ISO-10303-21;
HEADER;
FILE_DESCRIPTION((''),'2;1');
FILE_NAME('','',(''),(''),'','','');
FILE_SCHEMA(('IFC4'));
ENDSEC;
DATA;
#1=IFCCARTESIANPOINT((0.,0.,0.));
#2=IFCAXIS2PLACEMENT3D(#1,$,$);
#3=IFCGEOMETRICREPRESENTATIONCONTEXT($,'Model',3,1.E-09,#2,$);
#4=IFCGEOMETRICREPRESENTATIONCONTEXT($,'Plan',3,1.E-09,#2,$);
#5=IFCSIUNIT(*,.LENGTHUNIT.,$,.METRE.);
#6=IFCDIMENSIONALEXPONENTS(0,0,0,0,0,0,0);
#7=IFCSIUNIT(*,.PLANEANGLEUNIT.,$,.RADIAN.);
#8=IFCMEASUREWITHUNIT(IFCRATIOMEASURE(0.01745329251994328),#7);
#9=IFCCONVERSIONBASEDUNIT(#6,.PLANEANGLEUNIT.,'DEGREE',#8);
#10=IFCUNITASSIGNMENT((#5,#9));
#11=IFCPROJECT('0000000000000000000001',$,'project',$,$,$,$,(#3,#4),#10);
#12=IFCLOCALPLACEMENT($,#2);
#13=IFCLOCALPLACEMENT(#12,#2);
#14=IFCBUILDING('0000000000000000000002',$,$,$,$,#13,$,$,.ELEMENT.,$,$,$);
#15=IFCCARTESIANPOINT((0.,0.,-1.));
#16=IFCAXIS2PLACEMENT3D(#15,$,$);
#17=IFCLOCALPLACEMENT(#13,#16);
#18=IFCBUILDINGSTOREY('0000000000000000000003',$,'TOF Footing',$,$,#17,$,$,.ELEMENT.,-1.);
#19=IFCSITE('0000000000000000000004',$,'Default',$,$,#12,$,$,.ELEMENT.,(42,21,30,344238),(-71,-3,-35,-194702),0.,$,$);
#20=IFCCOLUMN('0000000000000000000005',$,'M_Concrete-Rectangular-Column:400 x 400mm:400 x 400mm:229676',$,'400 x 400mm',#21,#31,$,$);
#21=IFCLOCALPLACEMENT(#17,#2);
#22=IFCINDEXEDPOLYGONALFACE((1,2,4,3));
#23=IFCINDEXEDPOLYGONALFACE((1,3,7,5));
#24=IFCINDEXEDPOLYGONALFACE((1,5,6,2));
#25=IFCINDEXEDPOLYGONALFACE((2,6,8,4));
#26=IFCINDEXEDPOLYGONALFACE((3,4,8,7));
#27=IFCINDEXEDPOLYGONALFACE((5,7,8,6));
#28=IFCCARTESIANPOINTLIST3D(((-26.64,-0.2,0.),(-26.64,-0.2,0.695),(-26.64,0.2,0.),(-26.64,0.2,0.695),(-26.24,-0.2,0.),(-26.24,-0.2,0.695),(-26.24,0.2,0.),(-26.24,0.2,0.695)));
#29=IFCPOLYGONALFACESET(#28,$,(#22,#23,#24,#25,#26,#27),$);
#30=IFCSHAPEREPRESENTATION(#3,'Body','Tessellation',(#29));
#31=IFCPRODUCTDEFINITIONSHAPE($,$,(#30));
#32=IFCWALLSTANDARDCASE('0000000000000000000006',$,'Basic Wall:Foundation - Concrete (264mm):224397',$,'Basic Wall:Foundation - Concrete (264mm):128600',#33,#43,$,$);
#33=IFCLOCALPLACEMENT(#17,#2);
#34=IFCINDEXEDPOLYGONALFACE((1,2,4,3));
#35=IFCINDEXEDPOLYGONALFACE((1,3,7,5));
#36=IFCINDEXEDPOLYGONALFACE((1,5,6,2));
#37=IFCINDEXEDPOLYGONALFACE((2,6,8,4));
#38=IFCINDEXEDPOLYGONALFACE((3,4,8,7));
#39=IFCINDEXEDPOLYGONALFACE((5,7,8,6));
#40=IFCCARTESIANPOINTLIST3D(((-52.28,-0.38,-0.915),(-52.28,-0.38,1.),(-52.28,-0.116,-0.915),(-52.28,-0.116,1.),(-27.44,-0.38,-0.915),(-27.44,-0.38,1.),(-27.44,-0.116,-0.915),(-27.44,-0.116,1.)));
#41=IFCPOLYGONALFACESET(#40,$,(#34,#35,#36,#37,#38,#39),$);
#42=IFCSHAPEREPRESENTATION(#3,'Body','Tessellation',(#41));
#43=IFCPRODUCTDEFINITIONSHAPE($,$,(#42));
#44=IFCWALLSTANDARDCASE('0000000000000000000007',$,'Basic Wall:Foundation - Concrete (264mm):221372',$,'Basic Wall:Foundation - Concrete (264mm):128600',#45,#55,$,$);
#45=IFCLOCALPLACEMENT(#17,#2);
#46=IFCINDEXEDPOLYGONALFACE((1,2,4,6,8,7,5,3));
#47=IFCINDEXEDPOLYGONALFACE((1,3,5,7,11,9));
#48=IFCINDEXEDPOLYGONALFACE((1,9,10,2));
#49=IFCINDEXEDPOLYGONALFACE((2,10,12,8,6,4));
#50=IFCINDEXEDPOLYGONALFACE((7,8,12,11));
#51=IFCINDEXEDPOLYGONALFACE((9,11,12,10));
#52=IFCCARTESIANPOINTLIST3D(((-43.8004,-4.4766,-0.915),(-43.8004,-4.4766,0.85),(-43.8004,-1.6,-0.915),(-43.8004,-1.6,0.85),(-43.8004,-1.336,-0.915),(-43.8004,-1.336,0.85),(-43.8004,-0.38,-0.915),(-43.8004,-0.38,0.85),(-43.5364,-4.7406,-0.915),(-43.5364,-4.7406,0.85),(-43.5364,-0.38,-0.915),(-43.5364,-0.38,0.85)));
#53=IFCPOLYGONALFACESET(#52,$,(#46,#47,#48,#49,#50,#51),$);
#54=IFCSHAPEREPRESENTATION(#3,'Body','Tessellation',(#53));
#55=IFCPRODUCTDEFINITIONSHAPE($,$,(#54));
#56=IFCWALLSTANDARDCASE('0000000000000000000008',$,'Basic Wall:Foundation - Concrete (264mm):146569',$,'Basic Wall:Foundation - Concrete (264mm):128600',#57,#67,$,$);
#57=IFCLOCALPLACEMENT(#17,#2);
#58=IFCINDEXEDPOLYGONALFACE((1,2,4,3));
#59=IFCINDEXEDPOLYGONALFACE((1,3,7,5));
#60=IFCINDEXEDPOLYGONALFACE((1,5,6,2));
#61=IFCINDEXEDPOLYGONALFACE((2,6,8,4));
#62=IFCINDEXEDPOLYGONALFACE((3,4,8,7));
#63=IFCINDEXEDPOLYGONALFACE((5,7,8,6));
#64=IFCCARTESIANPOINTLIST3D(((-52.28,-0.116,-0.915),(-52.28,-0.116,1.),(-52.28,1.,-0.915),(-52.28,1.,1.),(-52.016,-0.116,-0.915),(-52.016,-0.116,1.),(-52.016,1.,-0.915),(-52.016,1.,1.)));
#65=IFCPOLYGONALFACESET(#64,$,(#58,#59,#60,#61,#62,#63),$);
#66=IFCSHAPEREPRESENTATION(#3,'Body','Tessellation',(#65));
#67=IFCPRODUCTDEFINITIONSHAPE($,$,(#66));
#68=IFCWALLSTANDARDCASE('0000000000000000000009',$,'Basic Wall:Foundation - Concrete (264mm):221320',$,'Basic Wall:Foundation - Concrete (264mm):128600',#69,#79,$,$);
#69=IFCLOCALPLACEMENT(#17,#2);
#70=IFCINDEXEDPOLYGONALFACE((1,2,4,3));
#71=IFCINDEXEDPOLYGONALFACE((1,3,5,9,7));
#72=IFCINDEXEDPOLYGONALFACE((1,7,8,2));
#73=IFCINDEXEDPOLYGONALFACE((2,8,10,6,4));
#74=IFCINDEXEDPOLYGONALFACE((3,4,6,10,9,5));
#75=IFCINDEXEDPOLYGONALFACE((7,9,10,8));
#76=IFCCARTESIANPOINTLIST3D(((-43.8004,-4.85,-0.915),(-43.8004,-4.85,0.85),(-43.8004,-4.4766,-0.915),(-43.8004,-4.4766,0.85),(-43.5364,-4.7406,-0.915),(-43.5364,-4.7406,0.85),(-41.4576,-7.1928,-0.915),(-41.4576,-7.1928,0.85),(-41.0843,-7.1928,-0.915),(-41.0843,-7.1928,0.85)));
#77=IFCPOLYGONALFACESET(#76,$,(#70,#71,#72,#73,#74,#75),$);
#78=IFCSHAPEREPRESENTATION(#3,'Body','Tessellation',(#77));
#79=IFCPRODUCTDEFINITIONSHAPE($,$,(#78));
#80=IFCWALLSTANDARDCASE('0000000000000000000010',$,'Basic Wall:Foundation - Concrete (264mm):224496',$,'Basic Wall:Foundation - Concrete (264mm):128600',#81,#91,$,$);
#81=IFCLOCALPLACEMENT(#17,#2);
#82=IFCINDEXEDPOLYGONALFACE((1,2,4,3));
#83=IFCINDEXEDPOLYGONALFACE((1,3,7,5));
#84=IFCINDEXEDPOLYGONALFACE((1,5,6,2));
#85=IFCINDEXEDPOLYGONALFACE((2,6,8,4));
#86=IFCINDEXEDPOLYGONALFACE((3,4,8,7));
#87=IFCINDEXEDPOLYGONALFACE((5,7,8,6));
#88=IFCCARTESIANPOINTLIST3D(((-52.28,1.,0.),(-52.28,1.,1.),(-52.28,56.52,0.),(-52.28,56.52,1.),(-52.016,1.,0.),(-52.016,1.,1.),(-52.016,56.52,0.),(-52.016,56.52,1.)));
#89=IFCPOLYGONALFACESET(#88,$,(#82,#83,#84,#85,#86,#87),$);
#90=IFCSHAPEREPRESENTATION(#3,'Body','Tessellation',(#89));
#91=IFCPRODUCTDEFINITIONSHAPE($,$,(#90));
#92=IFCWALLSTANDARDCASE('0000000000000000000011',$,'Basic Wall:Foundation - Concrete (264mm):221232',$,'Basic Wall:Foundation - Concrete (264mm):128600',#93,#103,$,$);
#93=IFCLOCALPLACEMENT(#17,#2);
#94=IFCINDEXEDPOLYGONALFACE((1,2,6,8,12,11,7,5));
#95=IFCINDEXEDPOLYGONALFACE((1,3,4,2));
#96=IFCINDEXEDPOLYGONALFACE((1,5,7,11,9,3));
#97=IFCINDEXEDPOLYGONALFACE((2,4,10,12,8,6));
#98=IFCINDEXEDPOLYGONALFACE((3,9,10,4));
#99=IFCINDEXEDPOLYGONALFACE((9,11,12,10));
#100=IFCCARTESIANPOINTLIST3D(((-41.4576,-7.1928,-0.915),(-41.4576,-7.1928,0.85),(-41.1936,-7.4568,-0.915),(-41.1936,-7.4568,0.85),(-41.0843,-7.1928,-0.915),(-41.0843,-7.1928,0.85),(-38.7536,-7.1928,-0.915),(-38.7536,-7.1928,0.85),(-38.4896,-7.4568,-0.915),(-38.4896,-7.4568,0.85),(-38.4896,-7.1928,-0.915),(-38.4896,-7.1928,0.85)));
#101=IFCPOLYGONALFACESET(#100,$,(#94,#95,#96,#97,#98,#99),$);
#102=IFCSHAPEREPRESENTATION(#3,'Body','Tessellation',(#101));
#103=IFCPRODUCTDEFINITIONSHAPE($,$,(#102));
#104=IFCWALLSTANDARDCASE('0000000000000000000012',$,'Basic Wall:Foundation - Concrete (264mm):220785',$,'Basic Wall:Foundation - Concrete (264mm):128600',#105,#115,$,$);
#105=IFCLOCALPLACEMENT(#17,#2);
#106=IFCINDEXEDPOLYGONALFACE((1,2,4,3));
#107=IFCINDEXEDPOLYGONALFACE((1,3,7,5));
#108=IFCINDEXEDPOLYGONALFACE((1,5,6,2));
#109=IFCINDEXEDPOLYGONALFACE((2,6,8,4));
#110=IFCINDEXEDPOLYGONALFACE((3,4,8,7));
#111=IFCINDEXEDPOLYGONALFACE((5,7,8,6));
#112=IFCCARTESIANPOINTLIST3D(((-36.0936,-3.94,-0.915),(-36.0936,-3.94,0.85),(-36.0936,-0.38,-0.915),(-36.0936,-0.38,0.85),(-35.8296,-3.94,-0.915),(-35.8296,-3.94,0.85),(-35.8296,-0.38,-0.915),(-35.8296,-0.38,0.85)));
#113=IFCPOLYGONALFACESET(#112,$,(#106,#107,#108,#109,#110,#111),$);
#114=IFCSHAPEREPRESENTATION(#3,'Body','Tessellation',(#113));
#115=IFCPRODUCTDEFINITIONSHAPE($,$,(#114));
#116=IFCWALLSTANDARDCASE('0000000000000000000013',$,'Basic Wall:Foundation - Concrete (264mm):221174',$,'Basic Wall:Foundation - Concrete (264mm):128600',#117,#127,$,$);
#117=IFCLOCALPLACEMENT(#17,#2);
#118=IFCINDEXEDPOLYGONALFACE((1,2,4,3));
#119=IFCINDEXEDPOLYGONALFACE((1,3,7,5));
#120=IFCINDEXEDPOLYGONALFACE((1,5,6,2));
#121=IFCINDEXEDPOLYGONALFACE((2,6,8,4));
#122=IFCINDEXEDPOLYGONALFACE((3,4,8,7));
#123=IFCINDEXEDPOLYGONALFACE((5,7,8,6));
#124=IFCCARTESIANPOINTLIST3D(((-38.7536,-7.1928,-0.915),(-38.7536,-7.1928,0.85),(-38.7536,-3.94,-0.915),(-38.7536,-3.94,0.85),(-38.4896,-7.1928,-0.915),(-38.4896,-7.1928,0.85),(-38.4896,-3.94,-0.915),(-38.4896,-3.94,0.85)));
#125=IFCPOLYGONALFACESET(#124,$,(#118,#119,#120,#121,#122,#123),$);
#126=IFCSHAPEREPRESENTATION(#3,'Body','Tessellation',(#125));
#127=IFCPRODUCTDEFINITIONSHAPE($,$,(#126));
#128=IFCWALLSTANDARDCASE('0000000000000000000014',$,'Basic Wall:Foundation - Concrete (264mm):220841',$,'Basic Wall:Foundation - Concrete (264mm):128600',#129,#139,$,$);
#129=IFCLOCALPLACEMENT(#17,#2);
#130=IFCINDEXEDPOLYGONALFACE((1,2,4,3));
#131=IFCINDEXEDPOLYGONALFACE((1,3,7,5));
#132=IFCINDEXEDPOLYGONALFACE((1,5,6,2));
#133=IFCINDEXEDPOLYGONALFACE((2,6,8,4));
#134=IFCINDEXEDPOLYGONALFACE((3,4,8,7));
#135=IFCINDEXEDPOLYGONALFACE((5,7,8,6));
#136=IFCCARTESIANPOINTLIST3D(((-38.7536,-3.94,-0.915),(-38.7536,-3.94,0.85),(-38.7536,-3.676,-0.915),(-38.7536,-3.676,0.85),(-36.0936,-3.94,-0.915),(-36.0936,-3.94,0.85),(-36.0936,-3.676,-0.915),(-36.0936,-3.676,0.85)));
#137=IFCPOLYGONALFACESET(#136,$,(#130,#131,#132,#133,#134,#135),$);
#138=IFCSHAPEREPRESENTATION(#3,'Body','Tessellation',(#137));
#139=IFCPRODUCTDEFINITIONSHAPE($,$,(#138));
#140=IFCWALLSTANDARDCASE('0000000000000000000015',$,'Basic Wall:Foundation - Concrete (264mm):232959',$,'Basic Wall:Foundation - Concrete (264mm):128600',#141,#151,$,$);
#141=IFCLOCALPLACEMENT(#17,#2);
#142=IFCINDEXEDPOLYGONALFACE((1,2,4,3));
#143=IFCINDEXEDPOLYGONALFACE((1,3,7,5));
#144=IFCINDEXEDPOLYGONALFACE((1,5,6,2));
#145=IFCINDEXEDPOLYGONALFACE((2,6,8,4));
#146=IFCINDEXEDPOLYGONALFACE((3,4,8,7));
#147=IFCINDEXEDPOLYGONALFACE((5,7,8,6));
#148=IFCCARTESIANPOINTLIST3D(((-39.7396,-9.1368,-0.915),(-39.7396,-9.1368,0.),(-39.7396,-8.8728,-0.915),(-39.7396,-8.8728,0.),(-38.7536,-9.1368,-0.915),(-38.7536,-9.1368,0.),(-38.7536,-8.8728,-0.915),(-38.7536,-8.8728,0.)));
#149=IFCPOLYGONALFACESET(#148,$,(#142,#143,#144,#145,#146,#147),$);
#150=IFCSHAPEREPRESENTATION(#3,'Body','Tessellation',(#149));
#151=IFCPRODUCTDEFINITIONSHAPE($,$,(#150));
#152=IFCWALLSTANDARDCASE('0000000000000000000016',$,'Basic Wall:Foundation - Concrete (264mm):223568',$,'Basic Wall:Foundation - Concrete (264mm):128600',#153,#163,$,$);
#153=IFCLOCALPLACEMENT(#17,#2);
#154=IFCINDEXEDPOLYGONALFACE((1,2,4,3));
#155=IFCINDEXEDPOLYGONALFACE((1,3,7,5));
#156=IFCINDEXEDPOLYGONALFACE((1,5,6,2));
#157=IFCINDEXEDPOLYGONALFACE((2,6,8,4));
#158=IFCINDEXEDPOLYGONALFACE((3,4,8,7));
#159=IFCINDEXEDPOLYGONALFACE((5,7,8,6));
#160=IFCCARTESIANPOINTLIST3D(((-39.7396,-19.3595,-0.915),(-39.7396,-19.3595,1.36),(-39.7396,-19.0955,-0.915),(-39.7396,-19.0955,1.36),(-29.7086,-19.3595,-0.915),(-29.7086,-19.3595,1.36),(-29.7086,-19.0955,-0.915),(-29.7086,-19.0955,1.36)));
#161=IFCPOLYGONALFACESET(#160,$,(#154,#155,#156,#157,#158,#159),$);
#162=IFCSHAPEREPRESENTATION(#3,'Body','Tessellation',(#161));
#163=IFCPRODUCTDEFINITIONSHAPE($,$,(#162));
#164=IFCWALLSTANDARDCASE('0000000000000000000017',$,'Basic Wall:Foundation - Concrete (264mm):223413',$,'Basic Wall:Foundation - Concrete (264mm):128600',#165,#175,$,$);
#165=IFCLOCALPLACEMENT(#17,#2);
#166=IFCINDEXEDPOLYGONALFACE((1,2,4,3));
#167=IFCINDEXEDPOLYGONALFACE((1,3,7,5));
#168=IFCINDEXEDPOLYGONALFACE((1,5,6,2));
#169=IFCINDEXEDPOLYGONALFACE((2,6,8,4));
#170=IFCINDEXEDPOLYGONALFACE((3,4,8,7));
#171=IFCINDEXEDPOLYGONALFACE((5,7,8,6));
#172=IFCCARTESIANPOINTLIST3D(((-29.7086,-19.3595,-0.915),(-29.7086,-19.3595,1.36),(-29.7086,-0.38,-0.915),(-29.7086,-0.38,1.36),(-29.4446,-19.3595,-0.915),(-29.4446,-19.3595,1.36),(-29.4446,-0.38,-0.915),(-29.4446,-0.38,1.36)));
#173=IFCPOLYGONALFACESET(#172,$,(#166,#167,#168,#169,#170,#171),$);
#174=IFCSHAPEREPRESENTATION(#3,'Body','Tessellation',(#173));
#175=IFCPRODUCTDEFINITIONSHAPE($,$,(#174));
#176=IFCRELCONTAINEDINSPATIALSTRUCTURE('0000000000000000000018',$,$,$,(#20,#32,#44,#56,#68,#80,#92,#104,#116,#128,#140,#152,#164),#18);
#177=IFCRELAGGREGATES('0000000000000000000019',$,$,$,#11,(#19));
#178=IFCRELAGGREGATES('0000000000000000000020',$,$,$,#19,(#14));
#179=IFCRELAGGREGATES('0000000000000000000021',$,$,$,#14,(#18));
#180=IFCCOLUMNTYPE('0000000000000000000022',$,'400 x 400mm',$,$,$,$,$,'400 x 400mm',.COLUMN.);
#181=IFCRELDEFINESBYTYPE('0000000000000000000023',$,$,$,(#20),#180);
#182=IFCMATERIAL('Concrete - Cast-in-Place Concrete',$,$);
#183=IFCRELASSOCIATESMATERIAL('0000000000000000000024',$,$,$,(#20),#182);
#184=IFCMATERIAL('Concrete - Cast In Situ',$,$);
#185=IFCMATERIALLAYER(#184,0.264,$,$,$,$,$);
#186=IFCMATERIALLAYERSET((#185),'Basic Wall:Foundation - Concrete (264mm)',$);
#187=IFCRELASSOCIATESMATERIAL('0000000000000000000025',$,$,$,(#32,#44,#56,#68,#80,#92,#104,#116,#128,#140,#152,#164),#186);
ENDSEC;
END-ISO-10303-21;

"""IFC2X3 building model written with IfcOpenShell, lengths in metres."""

from ifc_helpers import new_model, entity, si_unit, converted_unit, frame, frame_2d, origin, place, context, project, spatial, polyline, rectangle, outline, extrude, source, transform, mapped, material, layer, layer_set, layer_usage, type_object, type_shapes, element, save


model = new_model("IFC2X3")

# Units and contexts
model_context = context("Model", 3, precision=1e-09, world=origin())
plan_context = context("Plan", 3, precision=1e-09, world=origin())
ifc_project = project(units=[si_unit("LENGTHUNIT", "METRE"), converted_unit("PLANEANGLEUNIT", "DEGREE", entity("IfcRatioMeasure", 0.01745329251994328), si_unit("PLANEANGLEUNIT", "RADIAN"), dimensions=[0, 0, 0, 0, 0, 0, 0])], contexts=[model_context, plan_context])

# Site, building, storey
site_placement = place(None, origin())
site = spatial("IfcSite", under=ifc_project, at=site_placement, Name="Default", CompositionType="ELEMENT", RefLatitude=(42, 21, 30, 344238), RefLongitude=(-71, -3, -35, -194702), RefElevation=0.0)
building_placement = place(site_placement, origin())
building = spatial("IfcBuilding", under=site, at=building_placement, CompositionType="ELEMENT")
storey_placement = place(building_placement, frame((0.0, 0.0, -1.0)))
storey = spatial("IfcBuildingStorey", under=building, at=storey_placement, Name="TOF Footing", CompositionType="ELEMENT", Elevation=-1.0)

# Column
ifc_material_1 = material(Name="Concrete - Cast-in-Place Concrete")
column_type_1 = type_object("IfcColumnType", Name="400 x 400mm", ElementType="400 x 400mm", PredefinedType="COLUMN")
shared_shape_1 = source(origin(), model_context, "Body", "SweptSolid", [
    extrude(rectangle(XDim=0.4, YDim=0.4, at=frame_2d((0.0, 0.0), x_axis=(0.0, -1.0))), origin(), (0.0, 0.0, 1.0), 0.695),
])
type_shapes(column_type_1, [shared_shape_1])
column_placement = place(storey_placement, frame((-26.44, 0.0, 0.0), z_axis=(0.0, 0.0, 1.0), x_axis=(0.0, 1.0, 0.0)))
element("IfcColumn", 1, at=column_placement, inside=storey, type_object=column_type_1, material=ifc_material_1, Name="M_Concrete-Rectangular-Column:400 x 400mm:400 x 400mm:229676", ObjectType="400 x 400mm", context=model_context, shape_type="MappedRepresentation", body=[
    mapped(shared_shape_1, transform((0.0, 0.0, 0.0), scale=1.0)),
])

# Walls
ifc_material_2 = material(Name="Concrete - Cast In Situ")
ifc_layer = layer(ifc_material_2, 0.264)
ifc_layer_set = layer_set([ifc_layer], Name="Basic Wall:Foundation - Concrete (264mm)")
ifc_layer_usage = layer_usage(ifc_layer_set, "AXIS2", "NEGATIVE", 0.132)
wall_1_placement = place(storey_placement, frame((-27.44, -0.248, -0.915), z_axis=(0.0, 0.0, 1.0), x_axis=(-1.0, 0.0, 0.0)))
element("IfcWallStandardCase", 2, at=wall_1_placement, inside=storey, material=ifc_layer_usage, Name="Basic Wall:Foundation - Concrete (264mm):224397", ObjectType="Basic Wall:Foundation - Concrete (264mm):128600", context=model_context, shape_type="SweptSolid", body=[
    extrude(rectangle(XDim=24.84, YDim=0.264, at=frame_2d((12.42, 0.0), x_axis=(-1.0, 0.0))), origin(), (0.0, 0.0, 1.0), 1.915),
])
wall_2_placement = place(storey_placement, frame((-43.6684, -4.7406, -0.915), z_axis=(0.0, 0.0, 1.0), x_axis=(0.0, 1.0, 0.0)))
element("IfcWallStandardCase", 3, at=wall_2_placement, inside=storey, material=ifc_layer_usage, Name="Basic Wall:Foundation - Concrete (264mm):221372", ObjectType="Basic Wall:Foundation - Concrete (264mm):128600", context=model_context, shape_type="SweptSolid", body=[
    extrude(outline(polyline([(4.3606, -0.132), (4.3606, 0.132), (3.4046, 0.132), (3.1406, 0.132), (0.264, 0.132), (0.0, -0.132), (4.3606, -0.132)])), origin(), (0.0, 0.0, 1.0), 1.765),
])
wall_3_placement = place(storey_placement, frame((-52.148, -0.116, -0.915), z_axis=(0.0, 0.0, 1.0), x_axis=(0.0, 1.0, 0.0)))
element("IfcWallStandardCase", 4, at=wall_3_placement, inside=storey, material=ifc_layer_usage, Name="Basic Wall:Foundation - Concrete (264mm):146569", ObjectType="Basic Wall:Foundation - Concrete (264mm):128600", context=model_context, shape_type="SweptSolid", body=[
    extrude(rectangle(XDim=1.116, YDim=0.264, at=frame_2d((0.558, 0.0), x_axis=(-1.0, 0.0))), origin(), (0.0, 0.0, 1.0), 1.915),
])
wall_4_placement = place(storey_placement, frame((-41.1776, -7.2861, -0.915), z_axis=(0.0, 0.0, 1.0), x_axis=(-0.707107, 0.707107, 0.0)))
element("IfcWallStandardCase", 5, at=wall_4_placement, inside=storey, material=ifc_layer_usage, Name="Basic Wall:Foundation - Concrete (264mm):221320", ObjectType="Basic Wall:Foundation - Concrete (264mm):128600", context=model_context, shape_type="SweptSolid", body=[
    extrude(outline(polyline([(3.8412, -0.132), (3.5772, 0.132), (0.264, 0.132), (0.0, -0.132), (3.4678, -0.132), (3.8412, -0.132)])), origin(), (0.0, 0.0, 1.0), 1.765),
])
wall_5_placement = place(storey_placement, frame((-52.148, 1.0, 0.0), z_axis=(0.0, 0.0, 1.0), x_axis=(0.0, 1.0, 0.0)))
element("IfcWallStandardCase", 6, at=wall_5_placement, inside=storey, material=ifc_layer_usage, Name="Basic Wall:Foundation - Concrete (264mm):224496", ObjectType="Basic Wall:Foundation - Concrete (264mm):128600", context=model_context, shape_type="SweptSolid", body=[
    extrude(rectangle(XDim=55.52, YDim=0.264, at=frame_2d((27.76, 0.0), x_axis=(-1.0, 0.0))), origin(), (0.0, 0.0, 1.0), 1.0),
])

# Walls
wall_6_placement = place(storey_placement, frame((-38.4896, -7.3248, -0.915), z_axis=(0.0, 0.0, 1.0), x_axis=(-1.0, 0.0, 0.0)))
element("IfcWallStandardCase", 7, at=wall_6_placement, inside=storey, material=ifc_layer_usage, Name="Basic Wall:Foundation - Concrete (264mm):221232", ObjectType="Basic Wall:Foundation - Concrete (264mm):128600", context=model_context, shape_type="SweptSolid", body=[
    extrude(outline(polyline([(2.9681, -0.132), (2.7041, 0.132), (0.0, 0.132), (0.0, -0.132), (0.264, -0.132), (2.5947, -0.132), (2.9681, -0.132)])), origin(), (0.0, 0.0, 1.0), 1.765),
])
wall_7_placement = place(storey_placement, frame((-35.9616, -0.38, -0.915), z_axis=(0.0, 0.0, 1.0), x_axis=(0.0, -1.0, 0.0)))
element("IfcWallStandardCase", 8, at=wall_7_placement, inside=storey, material=ifc_layer_usage, Name="Basic Wall:Foundation - Concrete (264mm):220785", ObjectType="Basic Wall:Foundation - Concrete (264mm):128600", context=model_context, shape_type="SweptSolid", body=[
    extrude(rectangle(XDim=3.56, YDim=0.264, at=frame_2d((1.78, 0.0), x_axis=(-1.0, 0.0))), origin(), (0.0, 0.0, 1.0), 1.765),
])

# Walls
wall_8_placement = place(storey_placement, frame((-38.6216, -3.94, -0.915), z_axis=(0.0, 0.0, 1.0), x_axis=(0.0, -1.0, 0.0)))
element("IfcWallStandardCase", 9, at=wall_8_placement, inside=storey, material=ifc_layer_usage, Name="Basic Wall:Foundation - Concrete (264mm):221174", ObjectType="Basic Wall:Foundation - Concrete (264mm):128600", context=model_context, shape_type="SweptSolid", body=[
    extrude(rectangle(XDim=3.2528, YDim=0.264, at=frame_2d((1.6264, 0.0), x_axis=(-1.0, 0.0))), origin(), (0.0, 0.0, 1.0), 1.765),
])
wall_9_placement = place(storey_placement, frame((-36.0936, -3.808, -0.915), z_axis=(0.0, 0.0, 1.0), x_axis=(-1.0, 0.0, 0.0)))
element("IfcWallStandardCase", 10, at=wall_9_placement, inside=storey, material=ifc_layer_usage, Name="Basic Wall:Foundation - Concrete (264mm):220841", ObjectType="Basic Wall:Foundation - Concrete (264mm):128600", context=model_context, shape_type="SweptSolid", body=[
    extrude(rectangle(XDim=2.66, YDim=0.264, at=frame_2d((1.33, 0.0), x_axis=(-1.0, 0.0))), origin(), (0.0, 0.0, 1.0), 1.765),
])
wall_10_placement = place(storey_placement, frame((-38.7536, -9.0048, -0.915), z_axis=(0.0, 0.0, 1.0), x_axis=(-1.0, 0.0, 0.0)))
element("IfcWallStandardCase", 11, at=wall_10_placement, inside=storey, material=ifc_layer_usage, Name="Basic Wall:Foundation - Concrete (264mm):232959", ObjectType="Basic Wall:Foundation - Concrete (264mm):128600", context=model_context, shape_type="SweptSolid", body=[
    extrude(rectangle(XDim=0.986, YDim=0.264, at=frame_2d((0.493, 0.0), x_axis=(-1.0, 0.0))), origin(), (0.0, 0.0, 1.0), 0.915),
])
wall_11_placement = place(storey_placement, frame((-29.7086, -19.2275, -0.915), z_axis=(0.0, 0.0, 1.0), x_axis=(-1.0, 0.0, 0.0)))
element("IfcWallStandardCase", 12, at=wall_11_placement, inside=storey, material=ifc_layer_usage, Name="Basic Wall:Foundation - Concrete (264mm):223568", ObjectType="Basic Wall:Foundation - Concrete (264mm):128600", context=model_context, shape_type="SweptSolid", body=[
    extrude(rectangle(XDim=10.031, YDim=0.264, at=frame_2d((5.0155, 0.0), x_axis=(-1.0, 0.0))), origin(), (0.0, 0.0, 1.0), 2.275),
])
wall_12_placement = place(storey_placement, frame((-29.5766, -0.38, -0.915), z_axis=(0.0, 0.0, 1.0), x_axis=(0.0, -1.0, 0.0)))
element("IfcWallStandardCase", 13, at=wall_12_placement, inside=storey, material=ifc_layer_usage, Name="Basic Wall:Foundation - Concrete (264mm):223413", ObjectType="Basic Wall:Foundation - Concrete (264mm):128600", context=model_context, shape_type="SweptSolid", body=[
    extrude(rectangle(XDim=18.9795, YDim=0.264, at=frame_2d((9.4898, 0.0), x_axis=(-1.0, 0.0))), origin(), (0.0, 0.0, 1.0), 2.275),
])

save(model, "model.ifc")
